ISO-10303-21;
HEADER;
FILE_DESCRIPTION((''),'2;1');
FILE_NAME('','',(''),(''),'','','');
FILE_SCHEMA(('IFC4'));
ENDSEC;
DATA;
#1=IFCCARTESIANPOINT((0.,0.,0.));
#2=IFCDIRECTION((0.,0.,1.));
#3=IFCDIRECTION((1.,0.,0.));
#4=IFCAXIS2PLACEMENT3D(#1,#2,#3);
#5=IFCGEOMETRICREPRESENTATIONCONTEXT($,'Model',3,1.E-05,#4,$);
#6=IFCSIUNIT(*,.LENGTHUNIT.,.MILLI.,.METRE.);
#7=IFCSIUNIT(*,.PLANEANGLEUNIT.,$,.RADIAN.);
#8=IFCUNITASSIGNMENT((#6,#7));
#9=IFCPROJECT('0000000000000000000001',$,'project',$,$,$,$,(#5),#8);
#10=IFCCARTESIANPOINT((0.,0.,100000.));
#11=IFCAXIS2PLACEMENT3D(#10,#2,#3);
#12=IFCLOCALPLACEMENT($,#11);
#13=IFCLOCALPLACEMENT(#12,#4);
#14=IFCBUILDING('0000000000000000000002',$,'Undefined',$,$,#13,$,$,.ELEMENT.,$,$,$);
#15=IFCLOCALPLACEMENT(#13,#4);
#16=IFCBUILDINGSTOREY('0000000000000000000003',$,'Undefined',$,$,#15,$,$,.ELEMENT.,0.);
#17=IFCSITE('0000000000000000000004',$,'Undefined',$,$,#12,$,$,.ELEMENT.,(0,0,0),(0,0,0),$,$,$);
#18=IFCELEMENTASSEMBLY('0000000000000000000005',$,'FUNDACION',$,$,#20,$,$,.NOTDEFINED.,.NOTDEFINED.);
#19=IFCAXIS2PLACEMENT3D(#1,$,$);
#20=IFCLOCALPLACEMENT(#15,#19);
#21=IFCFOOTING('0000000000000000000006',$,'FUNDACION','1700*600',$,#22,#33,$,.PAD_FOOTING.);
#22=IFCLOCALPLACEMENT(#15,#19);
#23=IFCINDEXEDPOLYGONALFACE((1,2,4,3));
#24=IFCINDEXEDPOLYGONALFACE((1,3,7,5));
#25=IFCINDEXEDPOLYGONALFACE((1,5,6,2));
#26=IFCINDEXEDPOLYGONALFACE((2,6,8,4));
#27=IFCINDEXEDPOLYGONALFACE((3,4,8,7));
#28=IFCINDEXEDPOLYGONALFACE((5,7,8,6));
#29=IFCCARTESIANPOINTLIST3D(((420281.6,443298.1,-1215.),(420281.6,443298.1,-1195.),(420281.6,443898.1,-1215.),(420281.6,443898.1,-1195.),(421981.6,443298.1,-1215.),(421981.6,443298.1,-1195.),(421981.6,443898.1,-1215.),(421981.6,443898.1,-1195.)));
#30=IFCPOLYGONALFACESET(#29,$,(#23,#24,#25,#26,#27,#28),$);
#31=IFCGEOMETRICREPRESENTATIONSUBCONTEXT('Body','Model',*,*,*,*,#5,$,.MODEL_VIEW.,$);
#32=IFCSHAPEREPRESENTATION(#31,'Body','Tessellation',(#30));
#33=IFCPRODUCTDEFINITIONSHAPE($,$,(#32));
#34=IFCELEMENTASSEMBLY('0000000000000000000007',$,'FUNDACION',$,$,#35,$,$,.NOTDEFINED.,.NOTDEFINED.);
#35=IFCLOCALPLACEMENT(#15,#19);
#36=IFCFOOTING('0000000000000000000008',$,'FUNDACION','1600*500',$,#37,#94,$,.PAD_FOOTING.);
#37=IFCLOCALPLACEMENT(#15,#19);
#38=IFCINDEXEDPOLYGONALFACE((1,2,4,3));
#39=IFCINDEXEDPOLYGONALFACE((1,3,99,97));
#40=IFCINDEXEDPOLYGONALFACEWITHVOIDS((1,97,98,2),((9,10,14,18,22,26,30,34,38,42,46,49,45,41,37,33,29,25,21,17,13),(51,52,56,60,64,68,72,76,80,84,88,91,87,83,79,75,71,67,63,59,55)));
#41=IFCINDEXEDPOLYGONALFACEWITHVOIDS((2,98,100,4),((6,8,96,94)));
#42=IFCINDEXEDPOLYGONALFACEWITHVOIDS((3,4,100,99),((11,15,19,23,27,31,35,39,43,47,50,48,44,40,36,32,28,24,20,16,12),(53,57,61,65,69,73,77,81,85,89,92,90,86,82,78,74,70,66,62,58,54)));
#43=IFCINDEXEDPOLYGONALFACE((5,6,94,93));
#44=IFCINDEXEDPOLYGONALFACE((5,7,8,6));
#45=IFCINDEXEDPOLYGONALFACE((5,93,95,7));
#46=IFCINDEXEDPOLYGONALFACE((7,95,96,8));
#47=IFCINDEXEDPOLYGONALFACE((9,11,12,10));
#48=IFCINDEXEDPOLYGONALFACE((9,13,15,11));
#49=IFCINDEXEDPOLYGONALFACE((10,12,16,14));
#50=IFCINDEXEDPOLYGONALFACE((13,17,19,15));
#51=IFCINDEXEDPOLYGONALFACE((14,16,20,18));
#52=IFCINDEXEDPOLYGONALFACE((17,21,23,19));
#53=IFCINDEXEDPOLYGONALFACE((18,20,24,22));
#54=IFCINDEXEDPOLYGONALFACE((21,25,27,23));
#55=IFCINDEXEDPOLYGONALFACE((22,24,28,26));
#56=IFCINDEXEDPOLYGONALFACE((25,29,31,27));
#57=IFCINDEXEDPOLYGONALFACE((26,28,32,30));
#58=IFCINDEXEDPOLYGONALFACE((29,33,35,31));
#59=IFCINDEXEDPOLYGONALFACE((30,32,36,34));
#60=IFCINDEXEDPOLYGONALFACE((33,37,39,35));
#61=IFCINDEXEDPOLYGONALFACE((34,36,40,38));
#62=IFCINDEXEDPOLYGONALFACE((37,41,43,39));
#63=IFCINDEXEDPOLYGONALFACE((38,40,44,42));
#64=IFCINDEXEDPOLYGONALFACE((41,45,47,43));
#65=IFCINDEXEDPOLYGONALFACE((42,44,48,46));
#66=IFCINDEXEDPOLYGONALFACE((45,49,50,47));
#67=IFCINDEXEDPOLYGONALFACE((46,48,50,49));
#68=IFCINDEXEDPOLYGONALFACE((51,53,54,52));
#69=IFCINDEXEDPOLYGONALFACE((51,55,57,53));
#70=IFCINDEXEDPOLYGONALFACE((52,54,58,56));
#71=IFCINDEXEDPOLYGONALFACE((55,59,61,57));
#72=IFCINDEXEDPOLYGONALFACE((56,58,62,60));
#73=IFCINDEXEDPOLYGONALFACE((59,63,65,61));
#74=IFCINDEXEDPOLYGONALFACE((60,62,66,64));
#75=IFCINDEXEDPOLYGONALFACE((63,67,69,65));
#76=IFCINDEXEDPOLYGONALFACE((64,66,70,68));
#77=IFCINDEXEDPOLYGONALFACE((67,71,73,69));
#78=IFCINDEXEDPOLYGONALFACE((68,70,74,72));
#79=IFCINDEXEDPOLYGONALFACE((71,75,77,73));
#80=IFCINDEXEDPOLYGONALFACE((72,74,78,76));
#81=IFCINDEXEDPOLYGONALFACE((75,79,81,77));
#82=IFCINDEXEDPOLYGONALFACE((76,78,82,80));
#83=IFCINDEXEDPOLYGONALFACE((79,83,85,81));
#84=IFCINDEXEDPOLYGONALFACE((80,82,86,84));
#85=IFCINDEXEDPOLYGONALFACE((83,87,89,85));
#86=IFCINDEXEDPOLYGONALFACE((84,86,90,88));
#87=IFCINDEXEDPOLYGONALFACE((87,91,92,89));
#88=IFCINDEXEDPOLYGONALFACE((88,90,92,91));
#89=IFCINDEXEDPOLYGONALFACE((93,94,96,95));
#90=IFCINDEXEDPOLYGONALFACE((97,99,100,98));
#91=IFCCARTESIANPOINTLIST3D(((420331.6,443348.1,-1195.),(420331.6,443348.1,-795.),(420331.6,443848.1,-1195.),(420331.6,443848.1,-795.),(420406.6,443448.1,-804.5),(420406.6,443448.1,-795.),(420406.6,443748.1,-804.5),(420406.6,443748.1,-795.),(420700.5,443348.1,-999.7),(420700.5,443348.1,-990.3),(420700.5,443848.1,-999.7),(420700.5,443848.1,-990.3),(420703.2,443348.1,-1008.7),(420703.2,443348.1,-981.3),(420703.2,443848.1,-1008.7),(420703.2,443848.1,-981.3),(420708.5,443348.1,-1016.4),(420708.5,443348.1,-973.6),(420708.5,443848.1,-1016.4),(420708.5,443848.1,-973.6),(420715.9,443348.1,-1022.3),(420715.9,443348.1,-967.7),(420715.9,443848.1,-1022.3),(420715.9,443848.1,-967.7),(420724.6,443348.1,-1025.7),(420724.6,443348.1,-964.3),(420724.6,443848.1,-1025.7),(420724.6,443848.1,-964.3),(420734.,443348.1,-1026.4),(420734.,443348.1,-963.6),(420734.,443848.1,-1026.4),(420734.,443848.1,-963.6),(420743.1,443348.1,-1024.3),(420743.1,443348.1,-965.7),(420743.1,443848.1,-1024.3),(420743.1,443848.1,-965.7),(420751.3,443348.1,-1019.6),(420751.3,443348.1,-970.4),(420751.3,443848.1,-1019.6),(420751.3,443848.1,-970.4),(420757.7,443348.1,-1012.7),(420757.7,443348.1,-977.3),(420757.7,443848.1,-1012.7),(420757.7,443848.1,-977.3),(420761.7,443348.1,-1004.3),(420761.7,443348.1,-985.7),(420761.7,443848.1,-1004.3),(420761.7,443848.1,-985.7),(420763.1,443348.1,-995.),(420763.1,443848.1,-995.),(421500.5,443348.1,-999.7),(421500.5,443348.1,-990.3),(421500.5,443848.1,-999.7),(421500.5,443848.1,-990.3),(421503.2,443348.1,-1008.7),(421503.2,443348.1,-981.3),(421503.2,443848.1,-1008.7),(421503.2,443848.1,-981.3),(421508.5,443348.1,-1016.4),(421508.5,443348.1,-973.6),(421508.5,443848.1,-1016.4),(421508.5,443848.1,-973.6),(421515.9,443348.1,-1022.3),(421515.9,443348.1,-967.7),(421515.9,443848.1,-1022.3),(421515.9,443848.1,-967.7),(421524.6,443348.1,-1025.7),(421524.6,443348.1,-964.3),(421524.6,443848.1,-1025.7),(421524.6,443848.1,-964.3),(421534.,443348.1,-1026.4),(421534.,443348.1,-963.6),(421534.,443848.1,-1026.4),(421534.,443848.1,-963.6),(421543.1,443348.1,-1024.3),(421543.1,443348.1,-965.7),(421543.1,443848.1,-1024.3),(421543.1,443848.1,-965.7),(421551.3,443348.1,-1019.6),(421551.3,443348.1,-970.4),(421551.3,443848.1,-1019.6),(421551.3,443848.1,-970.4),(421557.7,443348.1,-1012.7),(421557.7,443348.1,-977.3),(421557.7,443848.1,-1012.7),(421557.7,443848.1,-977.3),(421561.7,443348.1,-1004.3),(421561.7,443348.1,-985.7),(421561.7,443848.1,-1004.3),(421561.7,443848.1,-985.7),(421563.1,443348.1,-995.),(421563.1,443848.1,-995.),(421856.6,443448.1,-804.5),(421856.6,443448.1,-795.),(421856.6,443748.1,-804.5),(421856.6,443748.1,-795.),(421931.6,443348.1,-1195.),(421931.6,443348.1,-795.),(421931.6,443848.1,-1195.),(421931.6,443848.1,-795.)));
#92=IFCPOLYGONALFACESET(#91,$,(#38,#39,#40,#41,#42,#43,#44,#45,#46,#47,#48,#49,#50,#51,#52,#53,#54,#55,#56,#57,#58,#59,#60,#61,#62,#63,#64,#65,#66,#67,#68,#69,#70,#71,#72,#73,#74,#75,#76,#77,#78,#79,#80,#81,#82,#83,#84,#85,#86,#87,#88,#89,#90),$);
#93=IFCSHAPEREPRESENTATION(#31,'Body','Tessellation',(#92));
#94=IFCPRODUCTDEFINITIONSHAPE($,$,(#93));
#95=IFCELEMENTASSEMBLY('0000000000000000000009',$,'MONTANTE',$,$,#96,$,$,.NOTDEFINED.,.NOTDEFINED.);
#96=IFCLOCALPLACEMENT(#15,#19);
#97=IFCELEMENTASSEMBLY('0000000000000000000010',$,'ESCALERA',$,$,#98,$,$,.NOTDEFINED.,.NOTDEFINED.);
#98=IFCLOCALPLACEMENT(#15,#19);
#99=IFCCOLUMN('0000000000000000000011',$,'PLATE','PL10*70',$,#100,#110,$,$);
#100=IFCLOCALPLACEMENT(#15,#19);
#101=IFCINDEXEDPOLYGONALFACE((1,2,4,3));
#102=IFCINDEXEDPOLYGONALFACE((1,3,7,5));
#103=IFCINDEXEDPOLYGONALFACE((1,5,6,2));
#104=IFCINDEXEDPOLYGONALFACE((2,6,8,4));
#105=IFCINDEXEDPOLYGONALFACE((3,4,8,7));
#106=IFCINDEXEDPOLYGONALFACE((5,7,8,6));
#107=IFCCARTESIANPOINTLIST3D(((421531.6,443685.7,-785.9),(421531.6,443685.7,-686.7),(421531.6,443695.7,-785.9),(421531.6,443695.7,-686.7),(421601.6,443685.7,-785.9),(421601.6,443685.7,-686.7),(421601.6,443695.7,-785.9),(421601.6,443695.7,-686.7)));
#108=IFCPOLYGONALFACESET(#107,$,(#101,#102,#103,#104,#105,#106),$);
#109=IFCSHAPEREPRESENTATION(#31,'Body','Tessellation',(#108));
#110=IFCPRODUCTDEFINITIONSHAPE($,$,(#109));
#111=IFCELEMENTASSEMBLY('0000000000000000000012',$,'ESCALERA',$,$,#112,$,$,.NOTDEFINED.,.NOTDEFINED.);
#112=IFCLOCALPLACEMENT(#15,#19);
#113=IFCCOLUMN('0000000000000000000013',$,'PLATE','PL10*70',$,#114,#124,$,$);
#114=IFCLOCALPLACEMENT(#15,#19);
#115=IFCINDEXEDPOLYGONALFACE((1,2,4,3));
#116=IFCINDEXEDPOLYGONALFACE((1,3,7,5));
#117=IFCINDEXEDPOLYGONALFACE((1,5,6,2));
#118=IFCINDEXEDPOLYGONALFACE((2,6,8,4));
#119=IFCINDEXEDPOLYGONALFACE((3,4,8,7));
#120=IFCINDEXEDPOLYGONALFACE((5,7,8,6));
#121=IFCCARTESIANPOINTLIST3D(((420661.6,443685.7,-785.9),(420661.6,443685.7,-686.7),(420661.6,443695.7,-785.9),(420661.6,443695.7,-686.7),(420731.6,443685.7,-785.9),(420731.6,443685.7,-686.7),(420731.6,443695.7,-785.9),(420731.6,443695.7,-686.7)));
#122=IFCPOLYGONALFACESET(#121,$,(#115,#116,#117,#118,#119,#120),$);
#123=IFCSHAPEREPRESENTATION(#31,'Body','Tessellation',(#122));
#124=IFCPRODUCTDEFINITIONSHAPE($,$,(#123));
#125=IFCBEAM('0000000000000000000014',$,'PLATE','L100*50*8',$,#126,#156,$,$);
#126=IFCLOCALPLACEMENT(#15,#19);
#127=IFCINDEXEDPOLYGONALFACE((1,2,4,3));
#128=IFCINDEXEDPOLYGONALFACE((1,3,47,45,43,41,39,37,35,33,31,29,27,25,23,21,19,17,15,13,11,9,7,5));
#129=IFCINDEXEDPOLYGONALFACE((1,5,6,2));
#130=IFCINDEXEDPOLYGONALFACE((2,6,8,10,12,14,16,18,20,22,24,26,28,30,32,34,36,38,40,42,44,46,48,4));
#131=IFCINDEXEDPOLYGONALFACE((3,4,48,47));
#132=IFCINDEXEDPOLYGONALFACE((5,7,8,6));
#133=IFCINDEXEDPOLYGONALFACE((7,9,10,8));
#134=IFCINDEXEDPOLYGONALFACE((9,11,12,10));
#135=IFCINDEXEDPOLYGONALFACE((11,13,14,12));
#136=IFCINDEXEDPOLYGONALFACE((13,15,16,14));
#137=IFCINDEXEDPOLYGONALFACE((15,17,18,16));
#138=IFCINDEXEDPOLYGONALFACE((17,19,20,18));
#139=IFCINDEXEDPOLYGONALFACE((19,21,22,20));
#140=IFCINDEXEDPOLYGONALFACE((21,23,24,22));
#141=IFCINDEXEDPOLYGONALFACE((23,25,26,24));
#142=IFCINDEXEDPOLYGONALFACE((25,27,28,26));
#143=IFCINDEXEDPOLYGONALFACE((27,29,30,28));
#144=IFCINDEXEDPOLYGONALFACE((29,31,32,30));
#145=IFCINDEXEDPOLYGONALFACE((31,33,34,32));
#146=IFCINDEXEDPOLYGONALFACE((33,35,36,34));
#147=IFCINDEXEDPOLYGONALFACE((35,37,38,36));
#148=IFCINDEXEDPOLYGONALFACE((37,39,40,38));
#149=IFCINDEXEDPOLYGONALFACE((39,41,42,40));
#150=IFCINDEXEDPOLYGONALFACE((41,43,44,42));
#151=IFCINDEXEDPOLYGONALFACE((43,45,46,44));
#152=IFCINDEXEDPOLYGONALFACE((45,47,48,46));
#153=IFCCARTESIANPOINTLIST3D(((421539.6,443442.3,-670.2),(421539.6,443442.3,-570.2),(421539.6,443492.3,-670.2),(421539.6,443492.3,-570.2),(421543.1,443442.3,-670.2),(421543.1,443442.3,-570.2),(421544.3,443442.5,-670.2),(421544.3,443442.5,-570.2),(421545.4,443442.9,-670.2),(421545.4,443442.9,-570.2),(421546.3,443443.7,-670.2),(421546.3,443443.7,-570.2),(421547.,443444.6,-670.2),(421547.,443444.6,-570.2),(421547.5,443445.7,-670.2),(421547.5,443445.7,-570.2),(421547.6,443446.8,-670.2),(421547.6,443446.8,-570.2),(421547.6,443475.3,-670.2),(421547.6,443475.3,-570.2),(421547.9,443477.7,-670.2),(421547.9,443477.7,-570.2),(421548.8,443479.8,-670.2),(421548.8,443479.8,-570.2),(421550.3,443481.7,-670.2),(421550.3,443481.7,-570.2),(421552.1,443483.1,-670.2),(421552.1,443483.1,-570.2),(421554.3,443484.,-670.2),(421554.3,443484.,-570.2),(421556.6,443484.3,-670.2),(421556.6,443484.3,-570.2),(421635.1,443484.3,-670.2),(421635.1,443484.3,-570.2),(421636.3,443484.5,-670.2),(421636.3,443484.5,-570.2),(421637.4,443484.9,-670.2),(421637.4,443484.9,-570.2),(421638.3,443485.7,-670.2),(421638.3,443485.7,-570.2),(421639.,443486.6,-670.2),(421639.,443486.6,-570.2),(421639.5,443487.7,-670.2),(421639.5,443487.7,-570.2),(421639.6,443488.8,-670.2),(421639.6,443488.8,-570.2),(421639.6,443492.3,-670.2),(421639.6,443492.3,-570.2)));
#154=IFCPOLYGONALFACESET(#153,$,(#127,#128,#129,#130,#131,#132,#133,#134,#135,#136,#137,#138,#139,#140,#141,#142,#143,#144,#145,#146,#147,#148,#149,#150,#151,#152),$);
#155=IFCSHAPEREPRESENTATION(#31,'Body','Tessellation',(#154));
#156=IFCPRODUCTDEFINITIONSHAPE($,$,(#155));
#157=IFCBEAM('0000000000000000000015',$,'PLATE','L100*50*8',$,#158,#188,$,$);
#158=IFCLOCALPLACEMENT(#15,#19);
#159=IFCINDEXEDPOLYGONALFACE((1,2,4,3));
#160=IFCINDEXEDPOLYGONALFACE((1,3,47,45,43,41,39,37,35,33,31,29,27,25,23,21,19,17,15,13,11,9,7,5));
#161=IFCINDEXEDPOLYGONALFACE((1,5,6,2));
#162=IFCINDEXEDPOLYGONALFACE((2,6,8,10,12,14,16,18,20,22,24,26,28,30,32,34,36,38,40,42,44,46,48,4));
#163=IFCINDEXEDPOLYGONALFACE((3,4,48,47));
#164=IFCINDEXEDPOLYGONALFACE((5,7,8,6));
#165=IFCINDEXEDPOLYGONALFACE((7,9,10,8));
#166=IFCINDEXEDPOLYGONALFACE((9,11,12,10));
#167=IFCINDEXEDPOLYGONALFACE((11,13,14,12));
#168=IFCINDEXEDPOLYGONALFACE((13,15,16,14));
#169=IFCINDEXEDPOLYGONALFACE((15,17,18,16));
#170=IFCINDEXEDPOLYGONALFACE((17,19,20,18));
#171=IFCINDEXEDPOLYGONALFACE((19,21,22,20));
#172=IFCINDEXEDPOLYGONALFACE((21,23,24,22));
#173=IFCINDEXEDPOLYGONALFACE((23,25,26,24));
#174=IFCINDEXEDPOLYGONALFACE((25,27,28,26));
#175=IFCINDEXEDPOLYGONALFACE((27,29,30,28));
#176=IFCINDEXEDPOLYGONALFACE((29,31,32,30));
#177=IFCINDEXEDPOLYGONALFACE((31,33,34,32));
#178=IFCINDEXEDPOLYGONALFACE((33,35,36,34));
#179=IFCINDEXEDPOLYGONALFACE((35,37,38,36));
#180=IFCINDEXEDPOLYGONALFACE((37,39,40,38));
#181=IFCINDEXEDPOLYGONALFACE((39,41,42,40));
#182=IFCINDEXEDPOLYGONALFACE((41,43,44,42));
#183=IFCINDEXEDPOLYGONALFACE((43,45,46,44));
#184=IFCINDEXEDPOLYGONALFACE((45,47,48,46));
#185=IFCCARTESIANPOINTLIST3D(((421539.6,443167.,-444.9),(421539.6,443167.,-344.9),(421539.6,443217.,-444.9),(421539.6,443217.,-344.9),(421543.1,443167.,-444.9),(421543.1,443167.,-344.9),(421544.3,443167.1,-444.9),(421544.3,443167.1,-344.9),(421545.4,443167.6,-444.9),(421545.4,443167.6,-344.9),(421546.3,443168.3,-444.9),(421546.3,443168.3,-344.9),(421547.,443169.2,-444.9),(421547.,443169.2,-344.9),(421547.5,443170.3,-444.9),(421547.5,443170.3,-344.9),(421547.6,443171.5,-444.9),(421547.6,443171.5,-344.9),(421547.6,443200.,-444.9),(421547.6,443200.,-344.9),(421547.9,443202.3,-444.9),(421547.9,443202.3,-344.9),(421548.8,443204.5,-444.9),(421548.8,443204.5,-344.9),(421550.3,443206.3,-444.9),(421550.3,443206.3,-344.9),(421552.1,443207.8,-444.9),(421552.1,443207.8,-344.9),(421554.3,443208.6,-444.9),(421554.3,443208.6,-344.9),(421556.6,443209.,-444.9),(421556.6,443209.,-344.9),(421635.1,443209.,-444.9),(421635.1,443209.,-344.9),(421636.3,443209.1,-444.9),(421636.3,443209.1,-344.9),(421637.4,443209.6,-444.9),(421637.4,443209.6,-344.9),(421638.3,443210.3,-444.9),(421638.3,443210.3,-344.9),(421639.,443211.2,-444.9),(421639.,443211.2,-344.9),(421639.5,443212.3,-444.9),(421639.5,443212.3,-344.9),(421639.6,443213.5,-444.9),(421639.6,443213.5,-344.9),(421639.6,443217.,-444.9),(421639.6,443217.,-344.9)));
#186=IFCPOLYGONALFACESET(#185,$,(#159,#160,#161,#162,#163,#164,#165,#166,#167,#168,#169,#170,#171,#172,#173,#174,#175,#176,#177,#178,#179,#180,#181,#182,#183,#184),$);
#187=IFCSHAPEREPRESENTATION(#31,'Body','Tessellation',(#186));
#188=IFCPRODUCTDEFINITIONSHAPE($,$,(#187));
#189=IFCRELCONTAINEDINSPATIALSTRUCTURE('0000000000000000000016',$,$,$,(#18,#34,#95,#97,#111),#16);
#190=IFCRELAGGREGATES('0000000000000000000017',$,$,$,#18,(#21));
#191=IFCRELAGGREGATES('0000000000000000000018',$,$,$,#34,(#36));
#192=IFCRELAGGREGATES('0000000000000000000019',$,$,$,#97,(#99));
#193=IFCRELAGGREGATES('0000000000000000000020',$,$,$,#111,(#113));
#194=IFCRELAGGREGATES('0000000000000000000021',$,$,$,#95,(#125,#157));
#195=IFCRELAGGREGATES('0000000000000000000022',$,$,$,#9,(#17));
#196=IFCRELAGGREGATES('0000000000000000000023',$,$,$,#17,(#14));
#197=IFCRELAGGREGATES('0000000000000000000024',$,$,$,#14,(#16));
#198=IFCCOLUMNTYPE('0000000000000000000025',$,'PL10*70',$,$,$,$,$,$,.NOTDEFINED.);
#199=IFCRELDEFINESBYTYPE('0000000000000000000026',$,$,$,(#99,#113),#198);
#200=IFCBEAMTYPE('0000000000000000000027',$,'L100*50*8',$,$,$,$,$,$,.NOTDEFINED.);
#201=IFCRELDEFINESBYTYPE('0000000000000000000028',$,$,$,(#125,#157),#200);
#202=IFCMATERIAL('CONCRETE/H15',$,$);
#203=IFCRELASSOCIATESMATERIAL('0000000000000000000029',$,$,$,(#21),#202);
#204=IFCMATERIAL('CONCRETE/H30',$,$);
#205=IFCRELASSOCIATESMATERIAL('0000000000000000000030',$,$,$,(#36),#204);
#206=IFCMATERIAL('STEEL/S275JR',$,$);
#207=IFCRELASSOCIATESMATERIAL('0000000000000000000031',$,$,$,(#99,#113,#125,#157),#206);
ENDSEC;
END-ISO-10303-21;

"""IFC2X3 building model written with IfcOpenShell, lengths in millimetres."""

from ifc_helpers import new_model, si_unit, frame, origin_with_axes, origin_2d_with_axis, place, context, subcontext, project, spatial, polyline, rectangle, circle, l_section, outline, extrude, boolean, material, type_object, element, aggregate, save


model = new_model("IFC2X3")

# Units and contexts
model_context = context("Model", 3, precision=1e-05, world=origin_with_axes())
body_context = subcontext(model_context, "Body", "Model", "MODEL_VIEW")
ifc_project = project(units=[si_unit("LENGTHUNIT", "METRE", prefix="MILLI"), si_unit("PLANEANGLEUNIT", "RADIAN")], contexts=[model_context])

# Site, building, storey
site_placement = place(None, frame((0.0, 0.0, 100000.0), z_axis=(0.0, 0.0, 1.0), x_axis=(1.0, 0.0, 0.0)))
site = spatial("IfcSite", under=ifc_project, at=site_placement, Name="Undefined", CompositionType="ELEMENT", RefLatitude=(0, 0, 0), RefLongitude=(0, 0, 0))
building_placement = place(site_placement, origin_with_axes())
building = spatial("IfcBuilding", under=site, at=building_placement, Name="Undefined", CompositionType="ELEMENT")
storey_placement = place(building_placement, origin_with_axes())
storey = spatial("IfcBuildingStorey", under=building, at=storey_placement, Name="Undefined", CompositionType="ELEMENT", Elevation=0.0)

# Element assemblies, footings
assembly_1_placement = place(storey_placement, origin_with_axes())
assembly_1 = element("IfcElementAssembly", 1, at=assembly_1_placement, inside=storey, Name="FUNDACION", AssemblyPlace="NOTDEFINED", PredefinedType="NOTDEFINED")
ifc_material_1 = material(Name="CONCRETE/H15")
footing_1_placement = place(assembly_1_placement, frame((421131.6, 443598.1, -1215.0), z_axis=(1.0, 0.0, 0.0), x_axis=(0.0, 0.0, 1.0)))
footing_1 = element("IfcFooting", 2, at=footing_1_placement, material=ifc_material_1, Name="FUNDACION", Description="1700*600", PredefinedType="PAD_FOOTING", context=body_context, shape_type="SweptSolid", body=[
    extrude(rectangle(XDim=600.0, YDim=1700.0, at=origin_2d_with_axis()), frame((20.0, 0.0, 0.0), z_axis=(-1.0, 0.0, 0.0), x_axis=(0.0, -1.0, 0.0)), (0.0, 0.0, 1.0), 20.0),
])
aggregate(assembly_1, [footing_1])
assembly_2_placement = place(storey_placement, origin_with_axes())
assembly_2 = element("IfcElementAssembly", 3, at=assembly_2_placement, inside=storey, Name="FUNDACION", AssemblyPlace="NOTDEFINED", PredefinedType="NOTDEFINED")
ifc_material_2 = material(Name="CONCRETE/H30")
footing_2_placement = place(assembly_2_placement, frame((421131.6, 443598.1, -1195.0), z_axis=(1.0, 0.0, 0.0), x_axis=(0.0, 0.0, 1.0)))
footing_2 = element("IfcFooting", 4, at=footing_2_placement, material=ifc_material_2, Name="FUNDACION", Description="1600*500", PredefinedType="PAD_FOOTING", context=body_context, shape_type="CSG", body=[
    boolean("DIFFERENCE", boolean("DIFFERENCE", boolean("DIFFERENCE", extrude(rectangle(XDim=500.0, YDim=1600.0, at=origin_2d_with_axis()), frame((400.0, 0.0, 0.0), z_axis=(-1.0, 0.0, 0.0), x_axis=(0.0, -1.0, 0.0)), (0.0, 0.0, 1.0), 400.0), extrude(circle(Radius=31.5, at=origin_2d_with_axis()), frame((200.0, -300.0, 400.0), z_axis=(0.0, 1.0, 0.0), x_axis=(0.0, 0.0, 1.0)), (0.0, 0.0, 1.0), 600.0)), extrude(circle(Radius=31.5, at=origin_2d_with_axis()), frame((200.0, -300.0, -400.0), z_axis=(0.0, 1.0, 0.0), x_axis=(0.0, 0.0, 1.0)), (0.0, 0.0, 1.0), 600.0)), extrude(outline(polyline([(0.0, 0.0), (1450.0, 0.0), (1450.0, 300.0), (0.0, 300.0), (0.0, 0.0)])), frame((409.5, 150.0, 725.0), z_axis=(-1.0, 0.0, 0.0), x_axis=(0.0, 0.0, -1.0)), (0.0, 0.0, 1.0), 19.0)),
])
aggregate(assembly_2, [footing_2])

# Element assemblies, columns
assembly_3_placement = place(storey_placement, origin_with_axes())
assembly_3 = element("IfcElementAssembly", 5, at=assembly_3_placement, inside=storey, Name="MONTANTE", AssemblyPlace="NOTDEFINED", PredefinedType="NOTDEFINED")
assembly_4_placement = place(storey_placement, origin_with_axes())
assembly_4 = element("IfcElementAssembly", 6, at=assembly_4_placement, inside=storey, Name="ESCALERA", AssemblyPlace="NOTDEFINED", PredefinedType="NOTDEFINED")
ifc_material_3 = material(Name="STEEL/S275JR")
column_type_1 = type_object("IfcColumnType", Name="PL10*70", PredefinedType="NOTDEFINED")
column_1_placement = place(assembly_4_placement, frame((421566.6, 443690.7, -785.9), z_axis=(0.0, 0.0, 1.0), x_axis=(-1.0, 0.0, 0.0)))
column_1 = element("IfcColumn", 7, at=column_1_placement, type_object=column_type_1, material=ifc_material_3, Name="PLATE", Description="PL10*70", context=body_context, shape_type="SweptSolid", body=[
    extrude(rectangle(XDim=10.0, YDim=70.0, at=origin_2d_with_axis()), frame((0.0, 0.0, 99.2), z_axis=(0.0, 0.0, -1.0), x_axis=(0.0, 1.0, 0.0)), (0.0, 0.0, 1.0), 99.2),
])
assembly_5_placement = place(storey_placement, origin_with_axes())
assembly_5 = element("IfcElementAssembly", 8, at=assembly_5_placement, inside=storey, Name="ESCALERA", AssemblyPlace="NOTDEFINED", PredefinedType="NOTDEFINED")
column_2_placement = place(assembly_5_placement, frame((420696.6, 443690.7, -785.9), z_axis=(0.0, 0.0, 1.0), x_axis=(-1.0, 0.0, 0.0)))
column_2 = element("IfcColumn", 9, at=column_2_placement, type_object=column_type_1, material=ifc_material_3, Name="PLATE", Description="PL10*70", context=body_context, shape_type="SweptSolid", body=[
    extrude(rectangle(XDim=10.0, YDim=70.0, at=origin_2d_with_axis()), frame((0.0, 0.0, 99.2), z_axis=(0.0, 0.0, -1.0), x_axis=(0.0, 1.0, 0.0)), (0.0, 0.0, 1.0), 99.2),
])

# Beams
beam_type_1 = type_object("IfcBeamType", Name="L100*50*8", PredefinedType="NOTDEFINED")
beam_1_placement = place(assembly_3_placement, frame((421589.6, 443467.3, -570.2), z_axis=(1.0, 0.000001, 0.0), x_axis=(0.0, 0.0, -1.0)))
beam_1 = element("IfcBeam", 10, at=beam_1_placement, type_object=beam_type_1, material=ifc_material_3, Name="PLATE", Description="L100*50*8", context=body_context, shape_type="SweptSolid", body=[
    extrude(l_section(Depth=100.0, Width=50.0, Thickness=8.0, FilletRadius=9.0, EdgeRadius=4.5, at=origin_2d_with_axis()), frame((100.0, 0.0, 0.0), z_axis=(-1.0, 0.0, 0.0), x_axis=(0.0, -1.0, 0.0)), (0.0, 0.0, 1.0), 100.0),
])
beam_2_placement = place(assembly_3_placement, frame((421589.6, 443192.0, -344.9), z_axis=(1.0, 0.000001, 0.0), x_axis=(0.0, 0.0, -1.0)))
beam_2 = element("IfcBeam", 11, at=beam_2_placement, type_object=beam_type_1, material=ifc_material_3, Name="PLATE", Description="L100*50*8", context=body_context, shape_type="SweptSolid", body=[
    extrude(l_section(Depth=100.0, Width=50.0, Thickness=8.0, FilletRadius=9.0, EdgeRadius=4.5, at=origin_2d_with_axis()), frame((100.0, 0.0, 0.0), z_axis=(-1.0, 0.0, 0.0), x_axis=(0.0, -1.0, 0.0)), (0.0, 0.0, 1.0), 100.0),
])
aggregate(assembly_4, [column_1])

aggregate(assembly_5, [column_2])

aggregate(assembly_3, [beam_1, beam_2])

save(model, "model.ifc")
